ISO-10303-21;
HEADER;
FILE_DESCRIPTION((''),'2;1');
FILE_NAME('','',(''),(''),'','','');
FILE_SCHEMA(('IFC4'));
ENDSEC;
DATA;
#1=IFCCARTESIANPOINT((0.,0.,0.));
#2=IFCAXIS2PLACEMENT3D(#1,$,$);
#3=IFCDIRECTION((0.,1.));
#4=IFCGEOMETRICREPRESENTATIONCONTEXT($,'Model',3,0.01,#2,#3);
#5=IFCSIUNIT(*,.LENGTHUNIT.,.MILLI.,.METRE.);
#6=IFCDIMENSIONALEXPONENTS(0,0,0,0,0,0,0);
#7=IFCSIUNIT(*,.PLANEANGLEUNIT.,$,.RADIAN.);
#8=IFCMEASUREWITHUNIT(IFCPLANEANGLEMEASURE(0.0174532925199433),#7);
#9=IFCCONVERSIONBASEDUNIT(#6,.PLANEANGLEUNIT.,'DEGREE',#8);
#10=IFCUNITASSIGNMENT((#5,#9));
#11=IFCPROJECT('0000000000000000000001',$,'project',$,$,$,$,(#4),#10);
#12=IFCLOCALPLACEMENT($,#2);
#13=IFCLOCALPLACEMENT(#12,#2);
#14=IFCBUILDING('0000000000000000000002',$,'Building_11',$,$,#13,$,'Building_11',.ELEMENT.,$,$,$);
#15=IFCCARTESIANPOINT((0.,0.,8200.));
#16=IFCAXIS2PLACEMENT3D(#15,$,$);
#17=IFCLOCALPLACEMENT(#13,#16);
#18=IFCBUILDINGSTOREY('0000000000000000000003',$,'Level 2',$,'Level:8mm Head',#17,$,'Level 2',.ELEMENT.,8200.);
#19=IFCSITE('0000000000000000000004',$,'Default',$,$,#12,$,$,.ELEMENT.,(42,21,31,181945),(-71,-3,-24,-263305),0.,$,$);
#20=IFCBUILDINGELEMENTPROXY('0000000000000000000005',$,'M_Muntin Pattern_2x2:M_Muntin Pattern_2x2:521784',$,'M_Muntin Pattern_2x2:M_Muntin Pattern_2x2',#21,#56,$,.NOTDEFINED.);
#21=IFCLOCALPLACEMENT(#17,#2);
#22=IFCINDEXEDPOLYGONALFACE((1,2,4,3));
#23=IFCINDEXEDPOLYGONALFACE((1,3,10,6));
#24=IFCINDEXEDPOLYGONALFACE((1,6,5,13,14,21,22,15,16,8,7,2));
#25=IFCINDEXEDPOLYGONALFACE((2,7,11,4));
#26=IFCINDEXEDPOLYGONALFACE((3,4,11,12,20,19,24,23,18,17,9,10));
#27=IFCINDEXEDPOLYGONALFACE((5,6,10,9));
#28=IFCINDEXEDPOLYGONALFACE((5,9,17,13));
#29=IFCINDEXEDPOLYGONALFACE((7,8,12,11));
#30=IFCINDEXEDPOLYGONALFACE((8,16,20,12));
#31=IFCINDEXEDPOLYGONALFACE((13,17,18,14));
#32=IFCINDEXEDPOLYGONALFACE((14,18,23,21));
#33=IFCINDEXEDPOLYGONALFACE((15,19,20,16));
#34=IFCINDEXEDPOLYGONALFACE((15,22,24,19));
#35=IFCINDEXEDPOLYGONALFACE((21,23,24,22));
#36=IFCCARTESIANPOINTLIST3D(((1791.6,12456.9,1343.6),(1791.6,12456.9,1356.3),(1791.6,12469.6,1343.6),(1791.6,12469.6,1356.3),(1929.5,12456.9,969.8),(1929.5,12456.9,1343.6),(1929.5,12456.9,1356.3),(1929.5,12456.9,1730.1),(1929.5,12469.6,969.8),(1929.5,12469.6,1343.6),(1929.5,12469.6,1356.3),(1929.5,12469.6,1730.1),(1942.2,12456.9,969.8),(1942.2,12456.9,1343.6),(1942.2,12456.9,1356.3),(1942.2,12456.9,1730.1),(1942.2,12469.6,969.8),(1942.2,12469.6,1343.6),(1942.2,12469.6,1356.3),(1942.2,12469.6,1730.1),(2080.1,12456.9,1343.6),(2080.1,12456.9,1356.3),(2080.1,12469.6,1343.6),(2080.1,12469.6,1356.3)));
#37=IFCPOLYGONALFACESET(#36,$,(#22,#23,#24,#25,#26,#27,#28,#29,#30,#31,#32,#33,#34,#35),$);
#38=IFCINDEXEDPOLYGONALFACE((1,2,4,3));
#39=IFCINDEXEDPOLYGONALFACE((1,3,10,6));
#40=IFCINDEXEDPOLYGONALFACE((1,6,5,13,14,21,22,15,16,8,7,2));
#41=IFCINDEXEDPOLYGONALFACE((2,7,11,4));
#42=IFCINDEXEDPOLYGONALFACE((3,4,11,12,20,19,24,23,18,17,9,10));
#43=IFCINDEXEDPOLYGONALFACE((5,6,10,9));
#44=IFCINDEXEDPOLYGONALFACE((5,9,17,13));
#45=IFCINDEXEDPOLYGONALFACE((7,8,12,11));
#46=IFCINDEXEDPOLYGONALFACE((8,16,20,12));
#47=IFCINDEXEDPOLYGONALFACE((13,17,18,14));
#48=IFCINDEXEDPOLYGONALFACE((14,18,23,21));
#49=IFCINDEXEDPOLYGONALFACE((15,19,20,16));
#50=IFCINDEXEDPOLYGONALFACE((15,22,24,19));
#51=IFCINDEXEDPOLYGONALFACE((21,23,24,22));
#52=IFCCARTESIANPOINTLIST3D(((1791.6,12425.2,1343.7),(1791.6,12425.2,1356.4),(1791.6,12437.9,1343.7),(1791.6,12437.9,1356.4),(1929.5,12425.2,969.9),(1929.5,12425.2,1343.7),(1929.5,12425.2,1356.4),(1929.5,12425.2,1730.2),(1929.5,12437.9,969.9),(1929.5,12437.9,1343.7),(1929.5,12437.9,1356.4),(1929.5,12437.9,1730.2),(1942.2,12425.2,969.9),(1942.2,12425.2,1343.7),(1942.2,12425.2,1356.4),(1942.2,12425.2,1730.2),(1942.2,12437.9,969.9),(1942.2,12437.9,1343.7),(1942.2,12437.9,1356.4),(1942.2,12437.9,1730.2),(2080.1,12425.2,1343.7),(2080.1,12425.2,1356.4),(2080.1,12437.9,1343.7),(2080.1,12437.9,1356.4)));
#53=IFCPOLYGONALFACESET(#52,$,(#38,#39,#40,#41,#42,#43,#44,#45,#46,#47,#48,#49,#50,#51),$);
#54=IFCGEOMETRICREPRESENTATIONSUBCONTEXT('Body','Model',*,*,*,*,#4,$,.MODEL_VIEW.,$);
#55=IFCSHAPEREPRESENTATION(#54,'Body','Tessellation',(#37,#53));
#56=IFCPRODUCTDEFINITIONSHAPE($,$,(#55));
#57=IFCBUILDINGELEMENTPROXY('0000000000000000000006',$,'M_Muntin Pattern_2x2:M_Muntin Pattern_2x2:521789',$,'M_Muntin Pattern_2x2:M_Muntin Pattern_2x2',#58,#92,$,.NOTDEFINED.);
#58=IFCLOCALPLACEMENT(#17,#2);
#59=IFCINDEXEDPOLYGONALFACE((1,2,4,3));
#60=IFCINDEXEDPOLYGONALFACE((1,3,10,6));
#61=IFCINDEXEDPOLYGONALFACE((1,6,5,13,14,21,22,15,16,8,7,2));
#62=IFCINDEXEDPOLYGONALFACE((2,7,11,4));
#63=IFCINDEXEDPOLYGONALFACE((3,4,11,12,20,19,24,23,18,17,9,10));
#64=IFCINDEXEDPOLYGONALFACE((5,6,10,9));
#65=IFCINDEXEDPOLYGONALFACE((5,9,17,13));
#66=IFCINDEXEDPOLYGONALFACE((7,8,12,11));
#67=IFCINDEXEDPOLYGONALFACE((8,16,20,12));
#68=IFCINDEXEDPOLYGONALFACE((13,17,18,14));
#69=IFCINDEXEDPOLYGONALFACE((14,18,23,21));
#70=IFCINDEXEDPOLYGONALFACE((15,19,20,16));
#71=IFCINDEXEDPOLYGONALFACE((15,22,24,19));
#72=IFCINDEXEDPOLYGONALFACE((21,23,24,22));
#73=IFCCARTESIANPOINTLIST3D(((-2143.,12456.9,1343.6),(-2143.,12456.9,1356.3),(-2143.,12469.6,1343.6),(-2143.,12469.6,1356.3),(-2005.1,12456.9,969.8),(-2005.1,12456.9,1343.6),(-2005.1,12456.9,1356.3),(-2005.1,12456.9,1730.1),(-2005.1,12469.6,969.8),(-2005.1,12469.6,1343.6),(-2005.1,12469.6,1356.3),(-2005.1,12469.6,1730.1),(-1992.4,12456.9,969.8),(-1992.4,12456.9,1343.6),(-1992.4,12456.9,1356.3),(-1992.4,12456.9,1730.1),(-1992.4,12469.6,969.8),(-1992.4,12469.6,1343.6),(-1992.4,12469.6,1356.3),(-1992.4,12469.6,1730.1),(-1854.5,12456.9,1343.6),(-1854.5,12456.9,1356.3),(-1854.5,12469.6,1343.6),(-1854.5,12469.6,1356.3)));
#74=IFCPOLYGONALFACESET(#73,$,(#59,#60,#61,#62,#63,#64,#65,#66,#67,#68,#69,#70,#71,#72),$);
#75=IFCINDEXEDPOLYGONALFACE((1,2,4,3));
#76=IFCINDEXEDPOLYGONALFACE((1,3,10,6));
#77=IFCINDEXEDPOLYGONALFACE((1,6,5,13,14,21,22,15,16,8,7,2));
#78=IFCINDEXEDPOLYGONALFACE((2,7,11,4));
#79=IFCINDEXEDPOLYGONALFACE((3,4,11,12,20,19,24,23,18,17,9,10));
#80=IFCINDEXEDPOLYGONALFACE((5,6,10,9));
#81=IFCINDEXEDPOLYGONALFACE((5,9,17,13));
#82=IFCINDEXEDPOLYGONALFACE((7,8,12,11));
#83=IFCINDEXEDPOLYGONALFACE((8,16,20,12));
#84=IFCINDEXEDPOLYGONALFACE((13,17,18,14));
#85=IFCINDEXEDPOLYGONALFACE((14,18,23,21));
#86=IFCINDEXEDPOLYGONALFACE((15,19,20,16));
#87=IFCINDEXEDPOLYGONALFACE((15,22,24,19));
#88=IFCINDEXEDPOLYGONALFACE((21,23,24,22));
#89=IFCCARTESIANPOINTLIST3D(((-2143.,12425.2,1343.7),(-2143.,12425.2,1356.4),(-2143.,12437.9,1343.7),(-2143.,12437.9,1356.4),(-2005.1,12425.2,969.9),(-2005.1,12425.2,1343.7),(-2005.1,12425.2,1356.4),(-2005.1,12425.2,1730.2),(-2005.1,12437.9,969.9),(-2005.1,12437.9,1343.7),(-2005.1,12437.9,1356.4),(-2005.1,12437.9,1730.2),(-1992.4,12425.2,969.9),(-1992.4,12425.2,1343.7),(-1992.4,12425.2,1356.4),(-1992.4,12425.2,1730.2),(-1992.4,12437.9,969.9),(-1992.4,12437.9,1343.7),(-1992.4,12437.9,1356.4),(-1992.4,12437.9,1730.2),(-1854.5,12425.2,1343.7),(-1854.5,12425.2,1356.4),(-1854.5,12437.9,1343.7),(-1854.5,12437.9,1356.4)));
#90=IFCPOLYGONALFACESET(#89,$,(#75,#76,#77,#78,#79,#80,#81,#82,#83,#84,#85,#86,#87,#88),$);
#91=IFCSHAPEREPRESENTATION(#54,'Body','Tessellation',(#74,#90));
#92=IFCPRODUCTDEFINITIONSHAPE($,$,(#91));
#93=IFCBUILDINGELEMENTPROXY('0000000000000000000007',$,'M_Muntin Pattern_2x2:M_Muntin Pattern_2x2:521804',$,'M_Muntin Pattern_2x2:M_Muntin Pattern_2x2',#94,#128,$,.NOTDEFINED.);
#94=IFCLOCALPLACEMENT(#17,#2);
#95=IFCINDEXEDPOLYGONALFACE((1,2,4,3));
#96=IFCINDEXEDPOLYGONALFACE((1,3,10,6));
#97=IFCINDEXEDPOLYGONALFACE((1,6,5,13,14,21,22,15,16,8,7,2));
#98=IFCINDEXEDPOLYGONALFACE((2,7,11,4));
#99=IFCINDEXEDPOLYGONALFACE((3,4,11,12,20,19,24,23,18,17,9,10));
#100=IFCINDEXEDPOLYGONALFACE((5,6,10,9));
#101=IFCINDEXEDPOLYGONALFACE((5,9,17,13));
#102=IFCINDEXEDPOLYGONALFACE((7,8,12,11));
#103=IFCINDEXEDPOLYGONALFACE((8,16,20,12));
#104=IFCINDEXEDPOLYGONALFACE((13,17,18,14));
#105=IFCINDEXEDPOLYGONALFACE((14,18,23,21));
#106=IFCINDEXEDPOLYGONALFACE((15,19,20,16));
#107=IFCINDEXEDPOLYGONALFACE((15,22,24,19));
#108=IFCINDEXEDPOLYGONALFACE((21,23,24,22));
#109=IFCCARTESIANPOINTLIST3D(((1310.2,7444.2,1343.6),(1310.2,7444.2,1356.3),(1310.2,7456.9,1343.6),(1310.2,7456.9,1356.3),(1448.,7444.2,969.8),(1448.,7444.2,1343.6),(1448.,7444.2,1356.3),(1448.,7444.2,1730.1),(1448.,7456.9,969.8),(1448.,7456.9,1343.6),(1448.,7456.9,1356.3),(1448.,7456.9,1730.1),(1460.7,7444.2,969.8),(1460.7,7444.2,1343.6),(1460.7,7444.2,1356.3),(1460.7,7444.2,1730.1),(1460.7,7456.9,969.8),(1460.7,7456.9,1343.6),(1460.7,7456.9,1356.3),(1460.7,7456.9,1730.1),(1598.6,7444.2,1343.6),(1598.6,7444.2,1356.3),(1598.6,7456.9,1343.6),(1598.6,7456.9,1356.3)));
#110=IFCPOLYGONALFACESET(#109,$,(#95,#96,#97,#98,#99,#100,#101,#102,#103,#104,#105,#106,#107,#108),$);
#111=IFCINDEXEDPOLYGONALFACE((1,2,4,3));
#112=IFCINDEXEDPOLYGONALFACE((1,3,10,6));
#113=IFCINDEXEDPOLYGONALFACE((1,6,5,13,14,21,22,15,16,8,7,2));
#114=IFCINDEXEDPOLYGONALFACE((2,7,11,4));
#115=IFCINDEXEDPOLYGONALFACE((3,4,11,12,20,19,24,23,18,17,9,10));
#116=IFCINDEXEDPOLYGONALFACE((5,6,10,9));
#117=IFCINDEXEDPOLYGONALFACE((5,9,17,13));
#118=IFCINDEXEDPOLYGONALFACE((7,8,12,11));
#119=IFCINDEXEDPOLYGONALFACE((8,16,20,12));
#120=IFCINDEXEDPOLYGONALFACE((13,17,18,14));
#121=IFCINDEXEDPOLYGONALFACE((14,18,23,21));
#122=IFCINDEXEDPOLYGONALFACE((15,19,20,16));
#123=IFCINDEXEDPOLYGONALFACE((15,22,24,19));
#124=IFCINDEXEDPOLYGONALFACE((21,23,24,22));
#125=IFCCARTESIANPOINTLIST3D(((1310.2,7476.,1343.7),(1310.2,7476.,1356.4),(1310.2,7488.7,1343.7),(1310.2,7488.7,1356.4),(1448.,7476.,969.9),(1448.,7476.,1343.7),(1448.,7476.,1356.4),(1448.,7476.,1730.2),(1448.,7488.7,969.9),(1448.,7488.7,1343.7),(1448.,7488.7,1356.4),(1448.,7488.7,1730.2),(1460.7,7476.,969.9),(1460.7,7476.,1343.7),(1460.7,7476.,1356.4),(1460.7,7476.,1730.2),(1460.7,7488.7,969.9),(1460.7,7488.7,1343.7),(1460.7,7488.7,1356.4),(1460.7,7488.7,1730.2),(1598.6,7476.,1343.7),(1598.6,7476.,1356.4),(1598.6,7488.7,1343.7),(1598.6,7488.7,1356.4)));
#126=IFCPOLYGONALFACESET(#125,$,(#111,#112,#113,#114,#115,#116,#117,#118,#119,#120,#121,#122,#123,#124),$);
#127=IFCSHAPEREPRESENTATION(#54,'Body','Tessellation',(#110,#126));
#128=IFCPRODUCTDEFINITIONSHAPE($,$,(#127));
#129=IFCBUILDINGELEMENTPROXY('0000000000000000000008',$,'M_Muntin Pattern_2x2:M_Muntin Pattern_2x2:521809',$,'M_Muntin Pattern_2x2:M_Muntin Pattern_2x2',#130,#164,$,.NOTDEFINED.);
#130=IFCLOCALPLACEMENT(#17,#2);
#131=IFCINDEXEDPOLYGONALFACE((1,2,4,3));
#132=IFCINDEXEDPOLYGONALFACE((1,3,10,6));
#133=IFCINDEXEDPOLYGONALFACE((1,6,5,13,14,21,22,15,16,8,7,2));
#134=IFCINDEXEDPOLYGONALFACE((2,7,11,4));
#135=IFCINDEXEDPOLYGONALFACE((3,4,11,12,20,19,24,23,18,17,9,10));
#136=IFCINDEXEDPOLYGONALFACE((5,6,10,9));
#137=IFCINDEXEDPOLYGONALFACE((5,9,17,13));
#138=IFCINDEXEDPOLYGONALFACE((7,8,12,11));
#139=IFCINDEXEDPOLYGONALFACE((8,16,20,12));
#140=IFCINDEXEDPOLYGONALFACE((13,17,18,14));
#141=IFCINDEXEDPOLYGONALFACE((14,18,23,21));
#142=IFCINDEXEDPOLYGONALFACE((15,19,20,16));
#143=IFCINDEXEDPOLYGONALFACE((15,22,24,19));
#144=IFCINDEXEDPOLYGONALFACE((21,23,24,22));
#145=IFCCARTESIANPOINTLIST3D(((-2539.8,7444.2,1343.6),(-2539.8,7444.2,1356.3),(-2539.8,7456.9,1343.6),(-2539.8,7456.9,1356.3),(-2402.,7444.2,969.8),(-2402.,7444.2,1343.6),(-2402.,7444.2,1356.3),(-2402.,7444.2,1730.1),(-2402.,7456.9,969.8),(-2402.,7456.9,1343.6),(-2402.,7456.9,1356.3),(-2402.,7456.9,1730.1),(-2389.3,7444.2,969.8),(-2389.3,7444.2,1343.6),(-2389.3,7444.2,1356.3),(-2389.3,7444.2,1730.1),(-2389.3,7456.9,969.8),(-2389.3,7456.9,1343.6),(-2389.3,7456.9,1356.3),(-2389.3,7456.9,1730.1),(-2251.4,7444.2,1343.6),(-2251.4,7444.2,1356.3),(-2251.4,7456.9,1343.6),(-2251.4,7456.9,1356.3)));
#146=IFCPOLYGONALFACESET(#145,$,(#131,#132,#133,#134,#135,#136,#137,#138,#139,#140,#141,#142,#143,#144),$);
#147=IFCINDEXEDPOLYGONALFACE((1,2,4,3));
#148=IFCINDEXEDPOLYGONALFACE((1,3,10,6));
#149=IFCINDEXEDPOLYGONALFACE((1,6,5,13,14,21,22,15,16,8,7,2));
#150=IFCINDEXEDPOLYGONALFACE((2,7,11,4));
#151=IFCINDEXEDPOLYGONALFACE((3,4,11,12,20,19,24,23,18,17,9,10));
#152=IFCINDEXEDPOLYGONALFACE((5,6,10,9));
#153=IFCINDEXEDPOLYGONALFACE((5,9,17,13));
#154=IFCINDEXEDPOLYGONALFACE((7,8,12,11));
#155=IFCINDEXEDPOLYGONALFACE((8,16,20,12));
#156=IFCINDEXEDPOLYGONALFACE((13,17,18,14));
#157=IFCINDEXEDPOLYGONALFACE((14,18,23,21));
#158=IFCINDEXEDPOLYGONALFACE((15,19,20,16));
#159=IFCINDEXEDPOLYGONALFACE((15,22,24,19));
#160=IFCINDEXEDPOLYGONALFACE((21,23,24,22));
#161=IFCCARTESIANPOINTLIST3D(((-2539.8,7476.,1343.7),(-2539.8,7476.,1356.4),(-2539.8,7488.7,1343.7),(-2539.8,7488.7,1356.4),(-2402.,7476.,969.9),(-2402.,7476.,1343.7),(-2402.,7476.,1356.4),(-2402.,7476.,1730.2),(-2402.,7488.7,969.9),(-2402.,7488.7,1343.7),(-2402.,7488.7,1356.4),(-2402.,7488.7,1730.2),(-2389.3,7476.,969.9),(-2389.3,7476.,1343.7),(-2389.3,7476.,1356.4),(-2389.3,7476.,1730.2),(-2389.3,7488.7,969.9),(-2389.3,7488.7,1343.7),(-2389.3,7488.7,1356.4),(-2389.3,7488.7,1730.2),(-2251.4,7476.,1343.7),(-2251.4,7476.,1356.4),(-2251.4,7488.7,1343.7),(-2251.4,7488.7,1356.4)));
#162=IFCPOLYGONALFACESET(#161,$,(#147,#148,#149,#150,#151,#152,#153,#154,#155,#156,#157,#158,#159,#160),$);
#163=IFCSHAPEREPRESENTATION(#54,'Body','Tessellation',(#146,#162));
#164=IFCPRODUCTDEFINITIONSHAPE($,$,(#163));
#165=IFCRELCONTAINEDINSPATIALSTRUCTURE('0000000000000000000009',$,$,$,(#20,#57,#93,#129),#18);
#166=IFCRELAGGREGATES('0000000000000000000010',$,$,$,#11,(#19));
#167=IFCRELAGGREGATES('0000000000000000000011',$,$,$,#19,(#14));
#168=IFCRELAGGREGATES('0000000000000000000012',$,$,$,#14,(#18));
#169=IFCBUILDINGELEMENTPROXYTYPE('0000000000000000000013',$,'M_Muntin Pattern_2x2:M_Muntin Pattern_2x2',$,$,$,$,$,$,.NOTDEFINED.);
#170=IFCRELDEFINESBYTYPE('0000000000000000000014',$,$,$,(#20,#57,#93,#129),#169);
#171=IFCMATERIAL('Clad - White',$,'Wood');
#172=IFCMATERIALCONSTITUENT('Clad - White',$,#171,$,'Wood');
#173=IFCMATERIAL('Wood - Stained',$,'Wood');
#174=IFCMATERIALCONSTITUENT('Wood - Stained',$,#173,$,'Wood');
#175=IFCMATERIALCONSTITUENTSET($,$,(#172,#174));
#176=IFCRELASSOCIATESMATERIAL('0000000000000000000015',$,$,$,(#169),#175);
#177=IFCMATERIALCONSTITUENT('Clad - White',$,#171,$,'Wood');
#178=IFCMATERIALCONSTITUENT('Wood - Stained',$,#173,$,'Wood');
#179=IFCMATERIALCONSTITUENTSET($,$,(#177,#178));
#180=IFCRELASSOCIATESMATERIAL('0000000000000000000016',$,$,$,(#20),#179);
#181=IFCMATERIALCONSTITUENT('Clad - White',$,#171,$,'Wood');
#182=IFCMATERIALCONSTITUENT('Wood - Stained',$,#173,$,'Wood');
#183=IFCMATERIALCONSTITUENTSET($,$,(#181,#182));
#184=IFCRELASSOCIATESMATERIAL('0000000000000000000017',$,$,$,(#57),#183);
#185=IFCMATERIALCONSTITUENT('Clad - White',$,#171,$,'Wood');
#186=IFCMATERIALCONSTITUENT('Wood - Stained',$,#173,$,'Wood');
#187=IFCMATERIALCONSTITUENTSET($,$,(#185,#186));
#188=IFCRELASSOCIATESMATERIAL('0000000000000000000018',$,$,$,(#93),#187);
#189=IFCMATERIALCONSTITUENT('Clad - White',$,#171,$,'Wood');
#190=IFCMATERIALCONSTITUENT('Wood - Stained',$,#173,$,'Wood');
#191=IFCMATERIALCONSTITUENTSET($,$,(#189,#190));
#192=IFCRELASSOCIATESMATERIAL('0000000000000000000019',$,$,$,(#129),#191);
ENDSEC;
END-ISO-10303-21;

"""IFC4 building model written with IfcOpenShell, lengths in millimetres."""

from ifc_helpers import new_model, entity, si_unit, converted_unit, direction, frame, origin, place, context, subcontext, project, spatial, indexed_curve, outline, extrude, source, transform, mapped, material, constituent, constituent_set, type_object, type_shapes, element, save


model = new_model("IFC4")

# Units and contexts
model_context = context("Model", 3, precision=0.01, world=origin(), true_north=direction((0.0, 1.0)))
body_context = subcontext(model_context, "Body", "Model", "MODEL_VIEW")
ifc_project = project(units=[si_unit("LENGTHUNIT", "METRE", prefix="MILLI"), converted_unit("PLANEANGLEUNIT", "DEGREE", entity("IfcPlaneAngleMeasure", 0.0174532925199433), si_unit("PLANEANGLEUNIT", "RADIAN"), dimensions=[0, 0, 0, 0, 0, 0, 0])], contexts=[model_context])

# Site, building, storey
site_placement = place(None, origin())
site = spatial("IfcSite", under=ifc_project, at=site_placement, Name="Default", CompositionType="ELEMENT", RefLatitude=(42, 21, 31, 181945), RefLongitude=(-71, -3, -24, -263305), RefElevation=0.0)
building_placement = place(site_placement, origin())
building = spatial("IfcBuilding", under=site, at=building_placement, Name="Building_11", LongName="Building_11", CompositionType="ELEMENT")
storey_placement = place(building_placement, frame((0.0, 0.0, 8200.0)))
storey = spatial("IfcBuildingStorey", under=building, at=storey_placement, Name="Level 2", ObjectType="Level:8mm Head", LongName="Level 2", CompositionType="ELEMENT", Elevation=8200.0)

# Building element proxies
ifc_material_1 = material(Name="Clad - White", Category="Wood")
ifc_material_2 = material(Name="Wood - Stained", Category="Wood")
ifc_constituent_1 = constituent(ifc_material_1, Name="Clad - White", Category="Wood")
ifc_constituent_2 = constituent(ifc_material_2, Name="Wood - Stained", Category="Wood")
ifc_constituent_set_1 = constituent_set(constituents=[ifc_constituent_1, ifc_constituent_2])
ifc_constituent_3 = constituent(ifc_material_1, Name="Clad - White", Category="Wood")
ifc_constituent_4 = constituent(ifc_material_2, Name="Wood - Stained", Category="Wood")
ifc_constituent_set_2 = constituent_set(constituents=[ifc_constituent_3, ifc_constituent_4])
building_element_proxy_type_1 = type_object("IfcBuildingElementProxyType", Name="M_Muntin Pattern_2x2:M_Muntin Pattern_2x2", PredefinedType="NOTDEFINED", material=ifc_constituent_set_2)
shared_shape_1 = source(origin(), body_context, "Body", "SweptSolid", [
    extrude(outline(indexed_curve([(6.4, -6.4), (380.1, -6.4), (380.1, 6.3), (6.4, 6.3), (6.4, 144.2), (-6.3, 144.2), (-6.3, 6.3), (-380.2, 6.3), (-380.2, -6.4), (-6.3, -6.4), (-6.3, -144.2), (6.4, -144.2), (6.4, -6.4)], self_intersect=False)), frame((0.0, -22.2, 380.1), z_axis=(0.0, 1.0, 0.0), x_axis=(0.0, 0.0, 1.0)), (0.0, 0.0, 1.0), 12.7),
    extrude(outline(indexed_curve([(6.4, -6.4), (380.2, -6.4), (380.2, 6.3), (6.4, 6.3), (6.4, 144.2), (-6.3, 144.2), (-6.3, 6.3), (-380.2, 6.3), (-380.2, -6.4), (-6.3, -6.4), (-6.3, -144.2), (6.4, -144.2), (6.4, -6.4)], self_intersect=False)), frame((0.0, 9.5, 380.2), z_axis=(0.0, 1.0, 0.0), x_axis=(0.0, 0.0, 1.0)), (0.0, 0.0, 1.0), 12.7),
])
type_shapes(building_element_proxy_type_1, [shared_shape_1])
proxy_1_placement = place(storey_placement, frame((1935.8, 12447.4, 969.9), z_axis=(0.0, 0.0, 1.0), x_axis=(-1.0, 0.0, 0.0)))
element("IfcBuildingElementProxy", 1, at=proxy_1_placement, inside=storey, type_object=building_element_proxy_type_1, material=ifc_constituent_set_1, Name="M_Muntin Pattern_2x2:M_Muntin Pattern_2x2:521784", ObjectType="M_Muntin Pattern_2x2:M_Muntin Pattern_2x2", PredefinedType="NOTDEFINED", context=body_context, shape_type="MappedRepresentation", body=[
    mapped(shared_shape_1, transform((0.0, 0.0, 0.0), scale=1.0)),
])
ifc_constituent_5 = constituent(ifc_material_1, Name="Clad - White", Category="Wood")
ifc_constituent_6 = constituent(ifc_material_2, Name="Wood - Stained", Category="Wood")
ifc_constituent_set_3 = constituent_set(constituents=[ifc_constituent_5, ifc_constituent_6])
proxy_2_placement = place(storey_placement, frame((-1998.8, 12447.4, 969.9), z_axis=(0.0, 0.0, 1.0), x_axis=(-1.0, 0.0, 0.0)))
element("IfcBuildingElementProxy", 2, at=proxy_2_placement, inside=storey, type_object=building_element_proxy_type_1, material=ifc_constituent_set_3, Name="M_Muntin Pattern_2x2:M_Muntin Pattern_2x2:521789", ObjectType="M_Muntin Pattern_2x2:M_Muntin Pattern_2x2", PredefinedType="NOTDEFINED", context=body_context, shape_type="MappedRepresentation", body=[
    mapped(shared_shape_1, transform((0.0, 0.0, 0.0), scale=1.0)),
])
ifc_constituent_7 = constituent(ifc_material_1, Name="Clad - White", Category="Wood")
ifc_constituent_8 = constituent(ifc_material_2, Name="Wood - Stained", Category="Wood")
ifc_constituent_set_4 = constituent_set(constituents=[ifc_constituent_7, ifc_constituent_8])
proxy_3_placement = place(storey_placement, frame((1454.4, 7466.4, 969.9)))
element("IfcBuildingElementProxy", 3, at=proxy_3_placement, inside=storey, type_object=building_element_proxy_type_1, material=ifc_constituent_set_4, Name="M_Muntin Pattern_2x2:M_Muntin Pattern_2x2:521804", ObjectType="M_Muntin Pattern_2x2:M_Muntin Pattern_2x2", PredefinedType="NOTDEFINED", context=body_context, shape_type="MappedRepresentation", body=[
    mapped(shared_shape_1, transform((0.0, 0.0, 0.0), scale=1.0)),
])
ifc_constituent_9 = constituent(ifc_material_1, Name="Clad - White", Category="Wood")
ifc_constituent_10 = constituent(ifc_material_2, Name="Wood - Stained", Category="Wood")
ifc_constituent_set_5 = constituent_set(constituents=[ifc_constituent_9, ifc_constituent_10])
proxy_4_placement = place(storey_placement, frame((-2395.6, 7466.4, 969.9)))
element("IfcBuildingElementProxy", 4, at=proxy_4_placement, inside=storey, type_object=building_element_proxy_type_1, material=ifc_constituent_set_5, Name="M_Muntin Pattern_2x2:M_Muntin Pattern_2x2:521809", ObjectType="M_Muntin Pattern_2x2:M_Muntin Pattern_2x2", PredefinedType="NOTDEFINED", context=body_context, shape_type="MappedRepresentation", body=[
    mapped(shared_shape_1, transform((0.0, 0.0, 0.0), scale=1.0)),
])

save(model, "model.ifc")
